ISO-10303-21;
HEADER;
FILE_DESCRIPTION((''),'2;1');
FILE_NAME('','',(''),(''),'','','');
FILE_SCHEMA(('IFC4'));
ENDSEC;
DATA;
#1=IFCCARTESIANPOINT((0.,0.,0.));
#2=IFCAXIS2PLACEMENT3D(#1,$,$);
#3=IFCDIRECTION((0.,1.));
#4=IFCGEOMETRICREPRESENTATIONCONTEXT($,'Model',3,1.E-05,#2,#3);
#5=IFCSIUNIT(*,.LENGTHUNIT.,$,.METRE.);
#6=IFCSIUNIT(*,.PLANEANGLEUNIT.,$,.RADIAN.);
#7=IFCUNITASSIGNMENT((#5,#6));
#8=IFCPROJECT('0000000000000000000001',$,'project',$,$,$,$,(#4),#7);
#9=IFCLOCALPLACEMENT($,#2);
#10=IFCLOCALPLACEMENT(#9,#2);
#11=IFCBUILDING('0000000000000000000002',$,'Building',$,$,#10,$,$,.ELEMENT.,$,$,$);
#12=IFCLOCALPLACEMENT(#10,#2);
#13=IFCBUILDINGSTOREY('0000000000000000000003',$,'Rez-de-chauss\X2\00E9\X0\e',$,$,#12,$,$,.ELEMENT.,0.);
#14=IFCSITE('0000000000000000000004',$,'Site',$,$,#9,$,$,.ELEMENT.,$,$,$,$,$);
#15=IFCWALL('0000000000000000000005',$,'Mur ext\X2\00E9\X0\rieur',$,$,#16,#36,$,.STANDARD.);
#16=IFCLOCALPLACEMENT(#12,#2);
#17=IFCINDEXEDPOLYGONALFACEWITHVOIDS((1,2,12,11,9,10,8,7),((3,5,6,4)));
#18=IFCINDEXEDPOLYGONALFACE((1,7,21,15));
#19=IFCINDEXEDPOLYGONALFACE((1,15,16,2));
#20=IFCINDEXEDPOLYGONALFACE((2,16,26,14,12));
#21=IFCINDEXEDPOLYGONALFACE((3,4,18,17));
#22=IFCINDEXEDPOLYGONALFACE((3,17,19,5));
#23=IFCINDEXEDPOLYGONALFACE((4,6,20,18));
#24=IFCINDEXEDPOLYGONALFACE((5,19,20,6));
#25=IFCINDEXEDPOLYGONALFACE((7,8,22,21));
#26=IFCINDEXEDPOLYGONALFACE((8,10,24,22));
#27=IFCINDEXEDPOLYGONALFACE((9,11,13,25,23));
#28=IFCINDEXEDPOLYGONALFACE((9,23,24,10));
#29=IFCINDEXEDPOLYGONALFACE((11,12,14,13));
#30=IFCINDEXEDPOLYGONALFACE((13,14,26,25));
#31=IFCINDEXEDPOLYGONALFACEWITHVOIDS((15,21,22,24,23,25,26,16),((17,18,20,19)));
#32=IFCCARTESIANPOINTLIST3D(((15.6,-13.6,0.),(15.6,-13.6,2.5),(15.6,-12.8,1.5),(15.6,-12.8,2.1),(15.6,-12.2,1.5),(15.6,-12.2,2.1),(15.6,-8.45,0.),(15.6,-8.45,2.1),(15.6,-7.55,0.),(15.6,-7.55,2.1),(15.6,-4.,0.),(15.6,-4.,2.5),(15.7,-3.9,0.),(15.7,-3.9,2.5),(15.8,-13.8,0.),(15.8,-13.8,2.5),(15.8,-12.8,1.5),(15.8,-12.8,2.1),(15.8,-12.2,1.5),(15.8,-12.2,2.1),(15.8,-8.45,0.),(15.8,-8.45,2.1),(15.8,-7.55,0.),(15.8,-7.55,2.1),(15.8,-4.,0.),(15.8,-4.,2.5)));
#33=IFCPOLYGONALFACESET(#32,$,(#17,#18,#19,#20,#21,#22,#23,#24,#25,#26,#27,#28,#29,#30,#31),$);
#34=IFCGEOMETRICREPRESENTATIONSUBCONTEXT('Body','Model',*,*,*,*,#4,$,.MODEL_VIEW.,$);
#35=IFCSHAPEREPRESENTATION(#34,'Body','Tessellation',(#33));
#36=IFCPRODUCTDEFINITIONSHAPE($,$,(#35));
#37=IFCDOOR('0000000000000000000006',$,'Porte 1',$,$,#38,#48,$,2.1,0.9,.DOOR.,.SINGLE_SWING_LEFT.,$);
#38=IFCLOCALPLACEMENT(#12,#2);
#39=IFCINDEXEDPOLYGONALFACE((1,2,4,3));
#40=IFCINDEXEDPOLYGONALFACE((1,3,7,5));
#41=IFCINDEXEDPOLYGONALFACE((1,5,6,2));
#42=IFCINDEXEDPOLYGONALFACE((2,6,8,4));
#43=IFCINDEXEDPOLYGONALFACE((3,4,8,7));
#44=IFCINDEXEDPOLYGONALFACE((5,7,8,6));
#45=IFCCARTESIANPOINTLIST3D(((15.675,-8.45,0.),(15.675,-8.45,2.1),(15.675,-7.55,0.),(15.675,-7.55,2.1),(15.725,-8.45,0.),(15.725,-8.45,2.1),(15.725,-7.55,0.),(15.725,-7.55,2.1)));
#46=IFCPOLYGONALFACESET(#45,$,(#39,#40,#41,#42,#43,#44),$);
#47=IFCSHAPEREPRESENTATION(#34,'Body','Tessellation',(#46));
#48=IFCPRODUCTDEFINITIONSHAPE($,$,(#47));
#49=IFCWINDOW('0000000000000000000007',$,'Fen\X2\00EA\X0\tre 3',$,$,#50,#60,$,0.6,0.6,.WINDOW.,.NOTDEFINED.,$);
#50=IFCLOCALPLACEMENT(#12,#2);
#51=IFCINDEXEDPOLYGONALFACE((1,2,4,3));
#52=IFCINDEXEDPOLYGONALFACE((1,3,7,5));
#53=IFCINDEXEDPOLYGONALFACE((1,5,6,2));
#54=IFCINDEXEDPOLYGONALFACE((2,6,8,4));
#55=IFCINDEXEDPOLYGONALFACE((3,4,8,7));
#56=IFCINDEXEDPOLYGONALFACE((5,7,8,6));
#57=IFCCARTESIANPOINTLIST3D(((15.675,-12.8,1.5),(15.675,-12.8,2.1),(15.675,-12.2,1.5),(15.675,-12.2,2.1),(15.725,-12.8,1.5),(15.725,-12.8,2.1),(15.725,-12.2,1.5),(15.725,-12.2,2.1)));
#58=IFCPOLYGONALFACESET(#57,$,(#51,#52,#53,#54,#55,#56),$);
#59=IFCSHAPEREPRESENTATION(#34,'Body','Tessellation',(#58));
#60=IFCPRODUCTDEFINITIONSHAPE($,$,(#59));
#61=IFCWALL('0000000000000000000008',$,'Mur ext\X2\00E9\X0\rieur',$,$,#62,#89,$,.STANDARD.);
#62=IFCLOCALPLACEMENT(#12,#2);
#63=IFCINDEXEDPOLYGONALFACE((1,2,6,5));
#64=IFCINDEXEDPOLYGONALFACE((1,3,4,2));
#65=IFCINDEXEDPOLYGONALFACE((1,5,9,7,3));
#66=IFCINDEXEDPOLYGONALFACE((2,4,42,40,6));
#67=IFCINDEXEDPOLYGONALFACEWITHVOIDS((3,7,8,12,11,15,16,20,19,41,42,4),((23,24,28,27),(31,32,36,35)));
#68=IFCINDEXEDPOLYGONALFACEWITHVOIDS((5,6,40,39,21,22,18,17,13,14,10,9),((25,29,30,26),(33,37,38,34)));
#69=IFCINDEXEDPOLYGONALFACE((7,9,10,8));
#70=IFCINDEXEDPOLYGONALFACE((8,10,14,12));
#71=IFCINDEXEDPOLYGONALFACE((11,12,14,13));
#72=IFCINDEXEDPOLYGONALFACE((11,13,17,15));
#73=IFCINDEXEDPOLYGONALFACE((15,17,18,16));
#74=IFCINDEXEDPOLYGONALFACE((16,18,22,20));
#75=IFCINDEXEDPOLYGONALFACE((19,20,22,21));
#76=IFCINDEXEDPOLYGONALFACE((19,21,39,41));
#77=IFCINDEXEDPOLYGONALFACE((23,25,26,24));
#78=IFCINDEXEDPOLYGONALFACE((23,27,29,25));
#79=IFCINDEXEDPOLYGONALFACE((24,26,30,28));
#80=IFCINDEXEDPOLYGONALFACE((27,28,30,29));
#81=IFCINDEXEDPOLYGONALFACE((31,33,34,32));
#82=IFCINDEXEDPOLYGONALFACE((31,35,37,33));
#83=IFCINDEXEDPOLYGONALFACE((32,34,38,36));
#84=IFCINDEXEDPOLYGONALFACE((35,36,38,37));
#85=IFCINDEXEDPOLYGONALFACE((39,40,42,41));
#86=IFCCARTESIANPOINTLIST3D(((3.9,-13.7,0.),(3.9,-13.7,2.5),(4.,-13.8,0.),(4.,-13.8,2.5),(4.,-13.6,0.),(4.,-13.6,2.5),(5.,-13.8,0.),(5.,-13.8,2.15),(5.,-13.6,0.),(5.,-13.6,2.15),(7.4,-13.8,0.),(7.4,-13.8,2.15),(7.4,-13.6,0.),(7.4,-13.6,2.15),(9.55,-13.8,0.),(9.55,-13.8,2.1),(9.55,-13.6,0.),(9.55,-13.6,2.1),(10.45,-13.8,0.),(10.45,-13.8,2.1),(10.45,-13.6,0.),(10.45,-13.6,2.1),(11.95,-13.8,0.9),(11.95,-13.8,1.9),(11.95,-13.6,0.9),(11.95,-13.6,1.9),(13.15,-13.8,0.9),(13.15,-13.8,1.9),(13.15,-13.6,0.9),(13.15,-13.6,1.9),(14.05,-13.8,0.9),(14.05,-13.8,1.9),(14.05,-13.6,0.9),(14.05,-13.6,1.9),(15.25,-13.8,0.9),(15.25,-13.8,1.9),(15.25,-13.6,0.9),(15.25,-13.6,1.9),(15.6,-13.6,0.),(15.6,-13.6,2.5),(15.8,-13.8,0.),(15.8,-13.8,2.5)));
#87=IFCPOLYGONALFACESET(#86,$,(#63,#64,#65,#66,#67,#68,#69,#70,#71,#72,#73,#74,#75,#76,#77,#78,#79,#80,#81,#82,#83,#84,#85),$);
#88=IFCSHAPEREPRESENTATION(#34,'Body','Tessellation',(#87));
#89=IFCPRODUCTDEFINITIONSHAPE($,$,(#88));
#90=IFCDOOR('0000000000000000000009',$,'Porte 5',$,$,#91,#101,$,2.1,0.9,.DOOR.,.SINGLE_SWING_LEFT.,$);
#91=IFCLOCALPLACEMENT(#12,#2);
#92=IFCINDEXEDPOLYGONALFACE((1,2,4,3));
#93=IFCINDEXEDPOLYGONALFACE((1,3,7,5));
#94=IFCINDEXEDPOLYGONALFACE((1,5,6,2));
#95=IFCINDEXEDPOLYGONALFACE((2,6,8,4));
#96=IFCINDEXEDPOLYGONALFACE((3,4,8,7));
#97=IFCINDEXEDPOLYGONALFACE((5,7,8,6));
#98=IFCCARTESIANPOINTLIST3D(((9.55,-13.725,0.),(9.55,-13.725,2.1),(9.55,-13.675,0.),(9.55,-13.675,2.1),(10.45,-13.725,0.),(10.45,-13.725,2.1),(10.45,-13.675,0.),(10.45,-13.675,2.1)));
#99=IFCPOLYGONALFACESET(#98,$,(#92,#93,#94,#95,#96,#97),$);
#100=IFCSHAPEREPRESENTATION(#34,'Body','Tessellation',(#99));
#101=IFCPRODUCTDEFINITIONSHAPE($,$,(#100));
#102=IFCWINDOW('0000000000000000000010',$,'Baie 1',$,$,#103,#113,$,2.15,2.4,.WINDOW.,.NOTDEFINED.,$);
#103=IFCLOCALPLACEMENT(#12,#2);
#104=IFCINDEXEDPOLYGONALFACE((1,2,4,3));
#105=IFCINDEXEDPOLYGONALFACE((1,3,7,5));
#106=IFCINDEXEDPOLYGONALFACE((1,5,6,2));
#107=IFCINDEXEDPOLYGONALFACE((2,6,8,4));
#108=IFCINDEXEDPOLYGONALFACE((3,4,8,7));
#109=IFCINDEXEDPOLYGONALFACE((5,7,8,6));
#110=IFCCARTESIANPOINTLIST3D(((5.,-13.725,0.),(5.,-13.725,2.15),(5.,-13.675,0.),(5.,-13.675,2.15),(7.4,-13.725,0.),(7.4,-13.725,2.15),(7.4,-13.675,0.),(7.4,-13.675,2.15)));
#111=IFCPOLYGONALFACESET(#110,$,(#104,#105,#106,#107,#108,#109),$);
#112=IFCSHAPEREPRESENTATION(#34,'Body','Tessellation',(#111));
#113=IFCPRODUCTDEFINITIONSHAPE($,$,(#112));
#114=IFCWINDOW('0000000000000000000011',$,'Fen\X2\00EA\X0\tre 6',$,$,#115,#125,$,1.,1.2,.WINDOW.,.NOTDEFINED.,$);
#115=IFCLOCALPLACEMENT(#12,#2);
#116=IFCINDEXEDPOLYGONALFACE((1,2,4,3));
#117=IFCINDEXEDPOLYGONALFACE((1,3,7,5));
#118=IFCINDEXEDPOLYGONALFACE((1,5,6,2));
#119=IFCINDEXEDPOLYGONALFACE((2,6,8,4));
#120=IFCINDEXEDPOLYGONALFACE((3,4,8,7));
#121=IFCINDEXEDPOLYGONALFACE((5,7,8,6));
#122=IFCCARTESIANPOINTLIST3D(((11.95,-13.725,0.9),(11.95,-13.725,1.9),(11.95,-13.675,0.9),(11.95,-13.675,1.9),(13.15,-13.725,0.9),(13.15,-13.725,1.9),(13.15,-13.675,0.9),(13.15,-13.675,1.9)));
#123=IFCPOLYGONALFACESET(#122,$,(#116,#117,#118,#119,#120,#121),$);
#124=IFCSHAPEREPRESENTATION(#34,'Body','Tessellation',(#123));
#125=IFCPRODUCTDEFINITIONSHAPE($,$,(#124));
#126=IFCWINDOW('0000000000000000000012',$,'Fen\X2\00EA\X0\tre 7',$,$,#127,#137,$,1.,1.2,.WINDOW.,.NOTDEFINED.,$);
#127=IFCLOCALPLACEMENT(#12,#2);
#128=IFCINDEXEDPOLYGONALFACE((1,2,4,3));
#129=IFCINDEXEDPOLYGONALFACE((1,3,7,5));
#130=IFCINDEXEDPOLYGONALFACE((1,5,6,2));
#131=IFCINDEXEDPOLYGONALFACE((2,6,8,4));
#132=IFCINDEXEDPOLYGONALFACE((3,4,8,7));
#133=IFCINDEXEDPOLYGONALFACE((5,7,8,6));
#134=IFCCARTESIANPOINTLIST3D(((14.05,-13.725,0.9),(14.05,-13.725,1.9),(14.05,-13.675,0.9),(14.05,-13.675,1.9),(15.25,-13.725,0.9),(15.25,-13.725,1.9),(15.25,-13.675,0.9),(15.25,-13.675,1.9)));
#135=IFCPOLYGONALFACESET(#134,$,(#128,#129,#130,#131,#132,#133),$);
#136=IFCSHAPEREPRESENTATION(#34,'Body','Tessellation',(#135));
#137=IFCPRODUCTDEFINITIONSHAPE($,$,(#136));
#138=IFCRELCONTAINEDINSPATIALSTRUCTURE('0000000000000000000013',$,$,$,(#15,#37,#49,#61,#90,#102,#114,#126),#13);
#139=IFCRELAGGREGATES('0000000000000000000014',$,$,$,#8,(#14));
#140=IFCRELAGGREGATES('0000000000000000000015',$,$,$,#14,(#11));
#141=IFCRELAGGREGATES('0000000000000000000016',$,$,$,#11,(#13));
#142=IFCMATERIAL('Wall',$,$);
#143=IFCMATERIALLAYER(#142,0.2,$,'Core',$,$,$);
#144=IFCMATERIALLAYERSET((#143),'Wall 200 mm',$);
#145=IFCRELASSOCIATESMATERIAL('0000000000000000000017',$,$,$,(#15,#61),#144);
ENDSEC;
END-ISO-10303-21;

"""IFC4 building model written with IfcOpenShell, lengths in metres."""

from ifc_helpers import new_model, si_unit, direction, frame, origin, origin_2d, place, context, subcontext, project, spatial, polyline, rectangle, outline, extrude, material, layer, layer_set, layer_usage, element, fill, save


model = new_model("IFC4")

# Units and contexts
model_context = context("Model", 3, precision=1e-05, world=origin(), true_north=direction((0.0, 1.0)))
body_context = subcontext(model_context, "Body", "Model", "MODEL_VIEW")
ifc_project = project(units=[si_unit("LENGTHUNIT", "METRE"), si_unit("PLANEANGLEUNIT", "RADIAN")], contexts=[model_context])

# Site, building, storey
site_placement = place(None, origin())
site = spatial("IfcSite", under=ifc_project, at=site_placement, Name="Site", CompositionType="ELEMENT")
building_placement = place(site_placement, origin())
building = spatial("IfcBuilding", under=site, at=building_placement, Name="Building", CompositionType="ELEMENT")
storey_placement = place(building_placement, origin())
storey = spatial("IfcBuildingStorey", under=building, at=storey_placement, Name="Rez-de-chaussée", CompositionType="ELEMENT", Elevation=0.0)

# Wall, openings, door, window
ifc_material = material(Name="Wall")
ifc_layer = layer(ifc_material, 0.2, Name="Core")
ifc_layer_set = layer_set([ifc_layer], Name="Wall 200 mm")
ifc_layer_usage = layer_usage(ifc_layer_set, "AXIS2", "POSITIVE", -0.1)
wall_1_placement = place(storey_placement, frame((15.7, -3.9, 0.0), z_axis=(0.0, 0.0, 1.0), x_axis=(0.0, -1.0, 0.0)))
wall_1 = element("IfcWall", 1, at=wall_1_placement, inside=storey, material=ifc_layer_usage, Name="Mur extérieur", PredefinedType="STANDARD", context=body_context, shape_type="SweptSolid", body=[
    extrude(outline(polyline([(0.0, 0.0), (0.1, -0.1), (9.7, -0.1), (9.8, 0.0), (9.9, 0.1), (0.1, 0.1), (0.0, 0.0)])), origin(), (0.0, 0.0, 1.0), 2.5),
])
opening_1_placement = place(wall_1_placement, frame((4.1, 0.0, 0.0)))
opening_1 = element("IfcOpeningElement", 2, at=opening_1_placement, cuts=wall_1, PredefinedType="OPENING", context=body_context, shape_type="SweptSolid", body=[
    extrude(rectangle(XDim=0.9, YDim=0.4, at=origin_2d()), origin(), (0.0, 0.0, 1.0), 2.1),
])
opening_2_placement = place(wall_1_placement, frame((8.6, 0.0, 1.5)))
opening_2 = element("IfcOpeningElement", 3, at=opening_2_placement, cuts=wall_1, PredefinedType="OPENING", context=body_context, shape_type="SweptSolid", body=[
    extrude(rectangle(XDim=0.6, YDim=0.4, at=origin_2d()), origin(), (0.0, 0.0, 1.0), 0.6),
])
door_1_placement = place(opening_1_placement, origin())
door_1 = element("IfcDoor", 4, at=door_1_placement, inside=storey, Name="Porte 1", OperationType="SINGLE_SWING_LEFT", OverallHeight=2.1, OverallWidth=0.9, PredefinedType="DOOR", context=body_context, shape_type="SweptSolid", body=[
    extrude(rectangle(XDim=0.9, YDim=0.05, at=origin_2d()), origin(), (0.0, 0.0, 1.0), 2.1),
])
fill(opening_1, door_1)
window_1_placement = place(opening_2_placement, origin())
window_1 = element("IfcWindow", 5, at=window_1_placement, inside=storey, Name="Fenêtre 3", OverallHeight=0.6, OverallWidth=0.6, PartitioningType="NOTDEFINED", PredefinedType="WINDOW", context=body_context, shape_type="SweptSolid", body=[
    extrude(rectangle(XDim=0.6, YDim=0.05, at=origin_2d()), origin(), (0.0, 0.0, 1.0), 0.6),
])
fill(opening_2, window_1)

# Wall, openings, door, windows
wall_2_placement = place(storey_placement, frame((15.7, -13.7, 0.0), z_axis=(0.0, 0.0, 1.0), x_axis=(-1.0, 0.0, 0.0)))
wall_2 = element("IfcWall", 6, at=wall_2_placement, inside=storey, material=ifc_layer_usage, Name="Mur extérieur", PredefinedType="STANDARD", context=body_context, shape_type="SweptSolid", body=[
    extrude(outline(polyline([(0.0, 0.0), (0.1, -0.1), (11.7, -0.1), (11.8, 0.0), (11.7, 0.1), (-0.1, 0.1), (0.0, 0.0)])), origin(), (0.0, 0.0, 1.0), 2.5),
])
opening_3_placement = place(wall_2_placement, frame((5.7, 0.0, 0.0), z_axis=(0.0, 0.0, 1.0), x_axis=(1.0, 0.0, 0.0)))
opening_3 = element("IfcOpeningElement", 7, at=opening_3_placement, cuts=wall_2, PredefinedType="OPENING", context=body_context, shape_type="SweptSolid", body=[
    extrude(rectangle(XDim=0.9, YDim=0.4, at=origin_2d()), origin(), (0.0, 0.0, 1.0), 2.1),
])
opening_4_placement = place(wall_2_placement, frame((9.5, 0.0, 0.0), z_axis=(0.0, 0.0, 1.0), x_axis=(1.0, 0.0, 0.0)))
opening_4 = element("IfcOpeningElement", 8, at=opening_4_placement, cuts=wall_2, PredefinedType="OPENING", context=body_context, shape_type="SweptSolid", body=[
    extrude(rectangle(XDim=2.4, YDim=0.4, at=origin_2d()), origin(), (0.0, 0.0, 1.0), 2.15),
])
opening_5_placement = place(wall_2_placement, frame((3.15, 0.0, 0.9), z_axis=(0.0, 0.0, 1.0), x_axis=(1.0, 0.0, 0.0)))
opening_5 = element("IfcOpeningElement", 9, at=opening_5_placement, cuts=wall_2, PredefinedType="OPENING", context=body_context, shape_type="SweptSolid", body=[
    extrude(rectangle(XDim=1.2, YDim=0.4, at=origin_2d()), origin(), (0.0, 0.0, 1.0), 1.0),
])
opening_6_placement = place(wall_2_placement, frame((1.05, 0.0, 0.9), z_axis=(0.0, 0.0, 1.0), x_axis=(1.0, 0.0, 0.0)))
opening_6 = element("IfcOpeningElement", 10, at=opening_6_placement, cuts=wall_2, PredefinedType="OPENING", context=body_context, shape_type="SweptSolid", body=[
    extrude(rectangle(XDim=1.2, YDim=0.4, at=origin_2d()), origin(), (0.0, 0.0, 1.0), 1.0),
])
door_2_placement = place(opening_3_placement, origin())
door_2 = element("IfcDoor", 11, at=door_2_placement, inside=storey, Name="Porte 5", OperationType="SINGLE_SWING_LEFT", OverallHeight=2.1, OverallWidth=0.9, PredefinedType="DOOR", context=body_context, shape_type="SweptSolid", body=[
    extrude(rectangle(XDim=0.9, YDim=0.05, at=origin_2d()), origin(), (0.0, 0.0, 1.0), 2.1),
])
fill(opening_3, door_2)
window_2_placement = place(opening_4_placement, origin())
window_2 = element("IfcWindow", 12, at=window_2_placement, inside=storey, Name="Baie 1", OverallHeight=2.15, OverallWidth=2.4, PartitioningType="NOTDEFINED", PredefinedType="WINDOW", context=body_context, shape_type="SweptSolid", body=[
    extrude(rectangle(XDim=2.4, YDim=0.05, at=origin_2d()), origin(), (0.0, 0.0, 1.0), 2.15),
])
fill(opening_4, window_2)
window_3_placement = place(opening_5_placement, origin())
window_3 = element("IfcWindow", 13, at=window_3_placement, inside=storey, Name="Fenêtre 6", OverallHeight=1.0, OverallWidth=1.2, PartitioningType="NOTDEFINED", PredefinedType="WINDOW", context=body_context, shape_type="SweptSolid", body=[
    extrude(rectangle(XDim=1.2, YDim=0.05, at=origin_2d()), origin(), (0.0, 0.0, 1.0), 1.0),
])
fill(opening_5, window_3)
window_4_placement = place(opening_6_placement, origin())
window_4 = element("IfcWindow", 14, at=window_4_placement, inside=storey, Name="Fenêtre 7", OverallHeight=1.0, OverallWidth=1.2, PartitioningType="NOTDEFINED", PredefinedType="WINDOW", context=body_context, shape_type="SweptSolid", body=[
    extrude(rectangle(XDim=1.2, YDim=0.05, at=origin_2d()), origin(), (0.0, 0.0, 1.0), 1.0),
])
fill(opening_6, window_4)

save(model, "model.ifc")
